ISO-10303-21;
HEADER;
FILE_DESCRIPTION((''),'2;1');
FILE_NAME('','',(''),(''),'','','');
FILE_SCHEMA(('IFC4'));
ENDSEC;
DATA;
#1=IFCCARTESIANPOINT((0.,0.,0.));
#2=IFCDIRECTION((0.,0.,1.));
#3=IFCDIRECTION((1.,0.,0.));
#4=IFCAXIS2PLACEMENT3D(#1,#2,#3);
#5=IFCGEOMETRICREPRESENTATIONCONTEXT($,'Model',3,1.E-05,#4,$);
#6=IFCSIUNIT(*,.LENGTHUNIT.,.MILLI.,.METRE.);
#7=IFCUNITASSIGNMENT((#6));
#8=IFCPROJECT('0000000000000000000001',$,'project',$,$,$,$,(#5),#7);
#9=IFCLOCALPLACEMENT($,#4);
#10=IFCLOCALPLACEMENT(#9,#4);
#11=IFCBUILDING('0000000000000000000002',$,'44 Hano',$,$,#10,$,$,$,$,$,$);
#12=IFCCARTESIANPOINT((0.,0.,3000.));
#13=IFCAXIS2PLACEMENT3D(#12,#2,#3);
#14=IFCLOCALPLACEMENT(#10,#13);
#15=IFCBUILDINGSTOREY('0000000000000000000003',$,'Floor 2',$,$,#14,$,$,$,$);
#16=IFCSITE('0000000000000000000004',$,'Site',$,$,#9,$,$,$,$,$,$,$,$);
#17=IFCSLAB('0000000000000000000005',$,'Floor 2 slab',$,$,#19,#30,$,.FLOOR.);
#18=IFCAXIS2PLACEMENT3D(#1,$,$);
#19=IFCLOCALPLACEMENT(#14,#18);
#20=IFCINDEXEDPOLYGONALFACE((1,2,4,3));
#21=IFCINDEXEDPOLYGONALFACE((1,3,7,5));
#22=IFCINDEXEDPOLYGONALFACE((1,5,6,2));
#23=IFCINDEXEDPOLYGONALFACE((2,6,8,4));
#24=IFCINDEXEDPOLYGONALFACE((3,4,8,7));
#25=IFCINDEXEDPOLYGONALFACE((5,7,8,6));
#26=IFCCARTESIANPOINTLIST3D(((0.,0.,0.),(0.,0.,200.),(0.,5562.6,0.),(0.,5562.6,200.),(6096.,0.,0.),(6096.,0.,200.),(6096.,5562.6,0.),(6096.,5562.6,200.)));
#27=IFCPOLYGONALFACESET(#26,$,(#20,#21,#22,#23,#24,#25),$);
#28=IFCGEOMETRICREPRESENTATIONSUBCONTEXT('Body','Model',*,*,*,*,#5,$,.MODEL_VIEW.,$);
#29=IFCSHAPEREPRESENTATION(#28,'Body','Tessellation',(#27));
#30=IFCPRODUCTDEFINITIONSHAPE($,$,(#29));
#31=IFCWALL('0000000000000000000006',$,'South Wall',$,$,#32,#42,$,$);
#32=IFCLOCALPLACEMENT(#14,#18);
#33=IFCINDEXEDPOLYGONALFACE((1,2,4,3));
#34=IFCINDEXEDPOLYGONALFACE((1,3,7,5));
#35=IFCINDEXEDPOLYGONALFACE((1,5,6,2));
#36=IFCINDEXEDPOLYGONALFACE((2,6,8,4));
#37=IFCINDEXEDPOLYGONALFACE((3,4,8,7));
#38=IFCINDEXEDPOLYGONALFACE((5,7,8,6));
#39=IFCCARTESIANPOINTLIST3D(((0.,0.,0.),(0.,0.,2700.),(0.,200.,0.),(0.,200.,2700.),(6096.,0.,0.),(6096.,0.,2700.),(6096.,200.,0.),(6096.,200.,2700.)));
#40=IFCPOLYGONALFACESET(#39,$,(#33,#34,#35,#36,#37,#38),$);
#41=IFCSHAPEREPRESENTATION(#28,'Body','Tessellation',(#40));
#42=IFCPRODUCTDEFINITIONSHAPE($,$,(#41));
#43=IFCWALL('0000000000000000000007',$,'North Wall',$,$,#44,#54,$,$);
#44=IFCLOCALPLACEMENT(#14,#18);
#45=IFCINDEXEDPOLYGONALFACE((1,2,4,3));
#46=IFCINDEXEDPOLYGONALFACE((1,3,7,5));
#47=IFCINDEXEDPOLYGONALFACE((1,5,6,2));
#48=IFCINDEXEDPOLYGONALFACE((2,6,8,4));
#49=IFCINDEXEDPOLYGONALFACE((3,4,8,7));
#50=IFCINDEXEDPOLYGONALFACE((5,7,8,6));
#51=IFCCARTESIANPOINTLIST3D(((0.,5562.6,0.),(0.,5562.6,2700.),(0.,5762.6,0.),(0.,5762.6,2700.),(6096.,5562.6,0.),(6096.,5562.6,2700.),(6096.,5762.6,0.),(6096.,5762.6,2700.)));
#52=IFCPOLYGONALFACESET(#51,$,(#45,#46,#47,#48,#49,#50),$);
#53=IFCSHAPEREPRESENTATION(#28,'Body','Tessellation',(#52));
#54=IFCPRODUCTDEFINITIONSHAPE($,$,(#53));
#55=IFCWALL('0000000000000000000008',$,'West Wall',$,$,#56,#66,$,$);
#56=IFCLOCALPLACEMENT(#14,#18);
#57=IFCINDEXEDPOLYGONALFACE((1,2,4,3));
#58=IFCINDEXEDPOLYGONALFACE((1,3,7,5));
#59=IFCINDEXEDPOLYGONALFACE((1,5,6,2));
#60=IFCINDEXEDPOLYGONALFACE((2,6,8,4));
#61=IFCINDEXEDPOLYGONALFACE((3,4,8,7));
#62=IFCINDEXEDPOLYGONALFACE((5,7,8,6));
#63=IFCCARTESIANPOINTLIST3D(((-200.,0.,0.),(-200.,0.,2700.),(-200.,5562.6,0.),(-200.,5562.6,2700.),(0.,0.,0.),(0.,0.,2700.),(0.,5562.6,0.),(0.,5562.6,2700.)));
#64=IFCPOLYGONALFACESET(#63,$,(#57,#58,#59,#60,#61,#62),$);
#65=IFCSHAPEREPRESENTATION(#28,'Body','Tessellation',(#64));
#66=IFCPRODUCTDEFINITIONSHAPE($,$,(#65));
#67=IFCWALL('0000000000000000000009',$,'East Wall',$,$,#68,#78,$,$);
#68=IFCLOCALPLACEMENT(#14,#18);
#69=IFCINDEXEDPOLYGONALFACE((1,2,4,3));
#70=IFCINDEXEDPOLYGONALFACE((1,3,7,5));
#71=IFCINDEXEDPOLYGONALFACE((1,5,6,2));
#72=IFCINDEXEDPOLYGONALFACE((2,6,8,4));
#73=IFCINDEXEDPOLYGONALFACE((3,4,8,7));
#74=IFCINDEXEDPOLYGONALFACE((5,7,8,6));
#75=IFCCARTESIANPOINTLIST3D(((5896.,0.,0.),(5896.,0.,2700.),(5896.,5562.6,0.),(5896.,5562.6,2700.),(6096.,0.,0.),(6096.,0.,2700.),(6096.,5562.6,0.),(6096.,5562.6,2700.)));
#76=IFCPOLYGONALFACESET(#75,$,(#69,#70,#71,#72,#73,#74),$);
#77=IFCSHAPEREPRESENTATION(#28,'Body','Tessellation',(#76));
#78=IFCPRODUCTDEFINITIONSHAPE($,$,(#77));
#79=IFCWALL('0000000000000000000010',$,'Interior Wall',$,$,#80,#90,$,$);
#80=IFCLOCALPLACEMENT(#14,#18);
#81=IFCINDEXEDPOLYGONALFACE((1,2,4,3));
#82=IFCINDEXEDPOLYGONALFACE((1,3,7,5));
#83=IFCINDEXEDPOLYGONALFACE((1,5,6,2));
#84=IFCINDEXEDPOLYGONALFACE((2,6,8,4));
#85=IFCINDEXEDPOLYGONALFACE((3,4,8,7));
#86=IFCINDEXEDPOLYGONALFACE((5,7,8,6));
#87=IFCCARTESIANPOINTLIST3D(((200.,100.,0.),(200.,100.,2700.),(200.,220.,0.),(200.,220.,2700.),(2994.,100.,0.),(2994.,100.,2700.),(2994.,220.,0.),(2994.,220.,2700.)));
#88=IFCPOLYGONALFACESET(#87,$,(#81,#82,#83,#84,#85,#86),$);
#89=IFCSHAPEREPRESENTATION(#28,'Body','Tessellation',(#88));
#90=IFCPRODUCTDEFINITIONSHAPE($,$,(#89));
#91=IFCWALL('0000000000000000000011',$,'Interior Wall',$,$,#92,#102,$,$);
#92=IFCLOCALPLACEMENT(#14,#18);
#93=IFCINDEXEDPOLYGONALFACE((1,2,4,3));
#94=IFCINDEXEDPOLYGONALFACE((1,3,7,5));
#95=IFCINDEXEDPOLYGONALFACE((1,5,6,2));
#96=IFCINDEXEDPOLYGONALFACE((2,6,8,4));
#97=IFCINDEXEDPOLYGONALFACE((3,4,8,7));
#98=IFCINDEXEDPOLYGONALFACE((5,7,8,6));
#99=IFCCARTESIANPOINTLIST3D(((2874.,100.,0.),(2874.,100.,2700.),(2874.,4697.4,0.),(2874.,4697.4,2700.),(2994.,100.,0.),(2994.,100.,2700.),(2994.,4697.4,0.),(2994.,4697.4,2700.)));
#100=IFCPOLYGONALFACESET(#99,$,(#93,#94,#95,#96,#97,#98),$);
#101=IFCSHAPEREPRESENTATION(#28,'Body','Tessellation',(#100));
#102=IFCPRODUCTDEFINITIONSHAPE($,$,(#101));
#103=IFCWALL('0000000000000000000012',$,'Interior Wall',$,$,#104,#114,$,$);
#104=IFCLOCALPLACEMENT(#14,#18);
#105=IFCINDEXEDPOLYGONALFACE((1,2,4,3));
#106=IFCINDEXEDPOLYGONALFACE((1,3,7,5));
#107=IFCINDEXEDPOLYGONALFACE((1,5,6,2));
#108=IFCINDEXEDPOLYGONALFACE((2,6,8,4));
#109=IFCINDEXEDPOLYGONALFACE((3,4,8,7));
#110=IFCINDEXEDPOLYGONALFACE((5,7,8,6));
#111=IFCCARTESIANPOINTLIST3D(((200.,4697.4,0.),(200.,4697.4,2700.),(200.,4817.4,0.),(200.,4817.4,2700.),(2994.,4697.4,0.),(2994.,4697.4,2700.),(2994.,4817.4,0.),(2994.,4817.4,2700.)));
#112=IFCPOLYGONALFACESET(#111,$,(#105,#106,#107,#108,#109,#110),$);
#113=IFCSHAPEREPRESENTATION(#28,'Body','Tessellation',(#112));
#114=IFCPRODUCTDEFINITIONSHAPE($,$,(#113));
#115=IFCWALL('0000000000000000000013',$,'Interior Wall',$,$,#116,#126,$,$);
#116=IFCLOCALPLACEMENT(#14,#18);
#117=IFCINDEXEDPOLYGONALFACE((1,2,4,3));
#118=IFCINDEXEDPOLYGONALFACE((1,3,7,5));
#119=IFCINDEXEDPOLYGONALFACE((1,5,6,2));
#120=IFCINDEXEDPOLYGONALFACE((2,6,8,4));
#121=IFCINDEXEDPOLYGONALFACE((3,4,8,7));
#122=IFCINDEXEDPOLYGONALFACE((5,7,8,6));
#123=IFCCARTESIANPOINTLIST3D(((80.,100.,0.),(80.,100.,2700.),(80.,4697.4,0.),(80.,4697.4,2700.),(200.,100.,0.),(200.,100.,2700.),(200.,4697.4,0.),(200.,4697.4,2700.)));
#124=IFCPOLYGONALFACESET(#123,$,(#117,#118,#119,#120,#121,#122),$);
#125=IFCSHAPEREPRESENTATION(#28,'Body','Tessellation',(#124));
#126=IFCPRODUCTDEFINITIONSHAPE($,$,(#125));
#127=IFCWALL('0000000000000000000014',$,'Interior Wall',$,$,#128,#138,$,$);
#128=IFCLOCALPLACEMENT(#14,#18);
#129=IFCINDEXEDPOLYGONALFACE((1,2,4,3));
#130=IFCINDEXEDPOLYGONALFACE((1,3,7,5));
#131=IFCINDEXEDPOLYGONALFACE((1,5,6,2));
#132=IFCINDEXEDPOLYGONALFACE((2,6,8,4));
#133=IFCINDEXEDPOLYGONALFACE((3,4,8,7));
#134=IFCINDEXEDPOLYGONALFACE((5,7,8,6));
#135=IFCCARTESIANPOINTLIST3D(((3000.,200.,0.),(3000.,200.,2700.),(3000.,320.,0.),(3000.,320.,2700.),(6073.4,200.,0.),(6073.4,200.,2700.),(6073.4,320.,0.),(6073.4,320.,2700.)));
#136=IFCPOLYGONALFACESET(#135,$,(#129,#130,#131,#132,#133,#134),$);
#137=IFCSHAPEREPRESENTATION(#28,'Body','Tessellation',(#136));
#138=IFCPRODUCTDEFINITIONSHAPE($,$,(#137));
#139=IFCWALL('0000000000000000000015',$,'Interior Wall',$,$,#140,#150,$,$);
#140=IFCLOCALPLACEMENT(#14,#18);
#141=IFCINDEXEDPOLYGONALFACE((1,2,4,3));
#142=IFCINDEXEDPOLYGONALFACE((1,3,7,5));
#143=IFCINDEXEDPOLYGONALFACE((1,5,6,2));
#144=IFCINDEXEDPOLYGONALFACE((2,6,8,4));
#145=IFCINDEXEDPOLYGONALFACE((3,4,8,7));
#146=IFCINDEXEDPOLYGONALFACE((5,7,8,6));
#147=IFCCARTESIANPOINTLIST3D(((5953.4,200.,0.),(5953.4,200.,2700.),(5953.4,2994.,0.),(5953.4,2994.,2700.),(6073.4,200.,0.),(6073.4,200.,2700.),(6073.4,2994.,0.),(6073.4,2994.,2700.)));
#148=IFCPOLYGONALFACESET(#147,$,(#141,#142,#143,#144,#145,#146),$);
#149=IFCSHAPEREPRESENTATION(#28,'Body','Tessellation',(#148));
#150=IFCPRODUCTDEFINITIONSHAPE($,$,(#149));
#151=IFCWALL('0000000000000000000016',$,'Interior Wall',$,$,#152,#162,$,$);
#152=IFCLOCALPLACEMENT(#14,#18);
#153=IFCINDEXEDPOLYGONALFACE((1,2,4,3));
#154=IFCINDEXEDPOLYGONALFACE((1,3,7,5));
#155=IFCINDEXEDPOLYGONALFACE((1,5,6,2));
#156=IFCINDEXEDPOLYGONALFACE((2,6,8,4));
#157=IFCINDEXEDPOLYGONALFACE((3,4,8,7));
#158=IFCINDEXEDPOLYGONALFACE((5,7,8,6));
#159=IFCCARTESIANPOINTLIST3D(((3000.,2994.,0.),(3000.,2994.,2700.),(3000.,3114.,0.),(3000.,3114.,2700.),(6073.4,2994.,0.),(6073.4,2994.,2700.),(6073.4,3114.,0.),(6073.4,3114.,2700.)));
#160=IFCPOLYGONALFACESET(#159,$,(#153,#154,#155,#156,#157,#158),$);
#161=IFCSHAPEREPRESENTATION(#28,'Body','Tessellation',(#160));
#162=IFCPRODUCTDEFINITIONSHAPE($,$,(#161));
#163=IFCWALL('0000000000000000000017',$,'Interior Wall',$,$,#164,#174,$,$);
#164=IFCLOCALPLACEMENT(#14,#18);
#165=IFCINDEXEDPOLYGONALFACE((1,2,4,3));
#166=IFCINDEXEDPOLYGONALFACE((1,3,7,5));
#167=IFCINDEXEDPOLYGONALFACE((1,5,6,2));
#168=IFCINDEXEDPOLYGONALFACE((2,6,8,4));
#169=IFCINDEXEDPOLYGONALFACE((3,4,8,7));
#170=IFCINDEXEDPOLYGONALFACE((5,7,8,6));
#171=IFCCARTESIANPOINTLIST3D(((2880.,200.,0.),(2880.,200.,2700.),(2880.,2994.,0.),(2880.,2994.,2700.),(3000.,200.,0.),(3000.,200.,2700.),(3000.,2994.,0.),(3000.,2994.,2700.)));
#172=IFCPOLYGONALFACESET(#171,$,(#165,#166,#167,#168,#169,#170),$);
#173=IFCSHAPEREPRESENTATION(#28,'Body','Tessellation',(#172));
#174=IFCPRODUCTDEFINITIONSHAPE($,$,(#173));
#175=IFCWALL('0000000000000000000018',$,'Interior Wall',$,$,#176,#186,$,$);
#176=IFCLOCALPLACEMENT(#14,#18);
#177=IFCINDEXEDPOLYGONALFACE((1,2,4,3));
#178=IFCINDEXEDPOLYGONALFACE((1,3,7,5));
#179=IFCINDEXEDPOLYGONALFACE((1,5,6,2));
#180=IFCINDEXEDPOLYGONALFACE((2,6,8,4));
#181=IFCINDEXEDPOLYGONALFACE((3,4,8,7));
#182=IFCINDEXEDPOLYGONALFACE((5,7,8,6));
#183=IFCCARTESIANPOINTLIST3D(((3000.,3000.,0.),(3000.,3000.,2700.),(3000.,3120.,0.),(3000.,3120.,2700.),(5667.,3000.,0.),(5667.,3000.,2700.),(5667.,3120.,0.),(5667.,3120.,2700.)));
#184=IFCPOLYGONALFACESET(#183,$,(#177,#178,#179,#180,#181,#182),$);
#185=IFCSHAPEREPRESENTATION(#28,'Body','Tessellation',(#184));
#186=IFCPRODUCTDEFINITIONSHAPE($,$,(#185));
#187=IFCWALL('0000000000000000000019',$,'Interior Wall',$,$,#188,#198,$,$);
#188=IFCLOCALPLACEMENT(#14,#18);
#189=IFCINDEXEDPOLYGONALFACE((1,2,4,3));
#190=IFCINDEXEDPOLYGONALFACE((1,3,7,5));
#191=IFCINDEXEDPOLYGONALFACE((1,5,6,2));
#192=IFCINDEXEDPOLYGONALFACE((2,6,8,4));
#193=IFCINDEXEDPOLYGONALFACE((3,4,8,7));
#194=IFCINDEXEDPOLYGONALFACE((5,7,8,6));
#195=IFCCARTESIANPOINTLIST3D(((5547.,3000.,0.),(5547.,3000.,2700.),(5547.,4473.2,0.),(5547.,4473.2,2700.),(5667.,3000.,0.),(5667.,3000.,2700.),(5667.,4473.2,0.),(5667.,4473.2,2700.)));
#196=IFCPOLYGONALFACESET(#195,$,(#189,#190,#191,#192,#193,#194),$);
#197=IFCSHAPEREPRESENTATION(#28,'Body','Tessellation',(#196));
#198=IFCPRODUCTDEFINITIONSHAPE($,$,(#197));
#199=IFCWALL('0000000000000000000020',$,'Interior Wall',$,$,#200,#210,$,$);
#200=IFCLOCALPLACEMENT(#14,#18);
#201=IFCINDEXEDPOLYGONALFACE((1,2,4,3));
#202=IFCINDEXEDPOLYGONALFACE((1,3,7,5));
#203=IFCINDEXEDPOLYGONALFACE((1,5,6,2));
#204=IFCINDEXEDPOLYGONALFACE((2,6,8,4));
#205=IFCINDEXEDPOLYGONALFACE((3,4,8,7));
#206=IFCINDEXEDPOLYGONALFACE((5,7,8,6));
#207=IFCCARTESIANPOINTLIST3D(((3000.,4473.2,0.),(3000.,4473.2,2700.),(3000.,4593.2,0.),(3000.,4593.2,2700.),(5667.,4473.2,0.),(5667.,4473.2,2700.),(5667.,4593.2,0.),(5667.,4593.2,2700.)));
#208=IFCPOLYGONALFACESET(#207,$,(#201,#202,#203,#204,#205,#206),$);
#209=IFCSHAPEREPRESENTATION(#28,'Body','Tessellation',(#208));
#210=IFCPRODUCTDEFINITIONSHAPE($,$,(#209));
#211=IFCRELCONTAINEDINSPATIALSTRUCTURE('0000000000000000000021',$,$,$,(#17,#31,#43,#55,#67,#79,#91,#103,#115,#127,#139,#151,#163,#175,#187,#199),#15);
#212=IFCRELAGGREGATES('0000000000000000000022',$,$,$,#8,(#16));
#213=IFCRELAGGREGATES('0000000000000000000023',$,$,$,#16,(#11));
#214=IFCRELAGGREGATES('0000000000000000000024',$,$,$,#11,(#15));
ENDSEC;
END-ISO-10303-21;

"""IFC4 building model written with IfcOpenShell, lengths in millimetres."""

from ifc_helpers import new_model, si_unit, frame, origin_with_axes, place, context, subcontext, project, spatial, indexed_curve, outline, extrude, element, save


model = new_model("IFC4")

# Units and contexts
model_context = context("Model", 3, precision=1e-05, world=origin_with_axes())
body_context = subcontext(model_context, "Body", "Model", "MODEL_VIEW")
ifc_project = project(units=[si_unit("LENGTHUNIT", "METRE", prefix="MILLI")], contexts=[model_context])

# Site, building, storey
site_placement = place(None, origin_with_axes())
site = spatial("IfcSite", under=ifc_project, at=site_placement, Name="Site")
building_placement = place(site_placement, origin_with_axes())
building = spatial("IfcBuilding", under=site, at=building_placement, Name="44 Hano")
storey_placement = place(building_placement, frame((0.0, 0.0, 3000.0), z_axis=(0.0, 0.0, 1.0), x_axis=(1.0, 0.0, 0.0)))
storey = spatial("IfcBuildingStorey", under=building, at=storey_placement, Name="Floor 2")

# Slab
slab_placement = place(storey_placement, origin_with_axes())
element("IfcSlab", 1, at=slab_placement, inside=storey, Name="Floor 2 slab", PredefinedType="FLOOR", context=body_context, shape_type="SweptSolid", body=[
    extrude(outline(indexed_curve([(0.0, 0.0), (6096.0, 0.0), (6096.0, 5562.6), (0.0, 5562.6), (0.0, 0.0)])), None, (0.0, 0.0, 1.0), 200.0),
])

# Walls
for number, where, z_axis, x_axis, name in (
    (2, (0.0, 0.0, 0.0), (0.0, 0.0, 1.0), (1.0, 0.0, 0.0), "South Wall"),
    (3, (0.0, 5562.6, 0.0), (0.0, 0.0, 1.0), (1.0, 0.0, 0.0), "North Wall"),
):
    element("IfcWall", number, at=place(storey_placement, frame(where, z_axis=z_axis, x_axis=x_axis)), inside=storey, Name=name, context=body_context, shape_type="SweptSolid", body=[
        extrude(outline(indexed_curve([(0.0, 0.0), (0.0, 200.0), (6096.0, 200.0), (6096.0, 0.0), (0.0, 0.0)], self_intersect=False)), origin_with_axes(), (0.0, 0.0, 1.0), 2700.0),
    ])
for number, where, z_axis, x_axis, name in (
    (4, (0.0, 0.0, 0.0), (0.0, 0.0, 1.0), (0.0, 1.0, 0.0), "West Wall"),
    (5, (6096.0, 0.0, 0.0), (0.0, 0.0, 1.0), (0.0, 1.0, 0.0), "East Wall"),
):
    element("IfcWall", number, at=place(storey_placement, frame(where, z_axis=z_axis, x_axis=x_axis)), inside=storey, Name=name, context=body_context, shape_type="SweptSolid", body=[
        extrude(outline(indexed_curve([(0.0, 0.0), (0.0, 200.0), (5562.6, 200.0), (5562.6, 0.0), (0.0, 0.0)], self_intersect=False)), origin_with_axes(), (0.0, 0.0, 1.0), 2700.0),
    ])
wall_1_placement = place(storey_placement, frame((200.0, 100.0, 0.0), z_axis=(0.0, 0.0, 1.0), x_axis=(1.0, 0.0, 0.0)))
element("IfcWall", 6, at=wall_1_placement, inside=storey, Name="Interior Wall", context=body_context, shape_type="SweptSolid", body=[
    extrude(outline(indexed_curve([(0.0, 0.0), (0.0, 120.0), (2794.0, 120.0), (2794.0, 0.0), (0.0, 0.0)], self_intersect=False)), origin_with_axes(), (0.0, 0.0, 1.0), 2700.0),
])
wall_2_placement = place(storey_placement, frame((2994.0, 100.0, 0.0), z_axis=(0.0, 0.0, 1.0), x_axis=(0.0, 1.0, 0.0)))
element("IfcWall", 7, at=wall_2_placement, inside=storey, Name="Interior Wall", context=body_context, shape_type="SweptSolid", body=[
    extrude(outline(indexed_curve([(0.0, 0.0), (0.0, 120.0), (4597.4, 120.0), (4597.4, 0.0), (0.0, 0.0)], self_intersect=False)), origin_with_axes(), (0.0, 0.0, 1.0), 2700.0),
])
wall_3_placement = place(storey_placement, frame((200.0, 4697.4, 0.0), z_axis=(0.0, 0.0, 1.0), x_axis=(1.0, 0.0, 0.0)))
element("IfcWall", 8, at=wall_3_placement, inside=storey, Name="Interior Wall", context=body_context, shape_type="SweptSolid", body=[
    extrude(outline(indexed_curve([(0.0, 0.0), (0.0, 120.0), (2794.0, 120.0), (2794.0, 0.0), (0.0, 0.0)], self_intersect=False)), origin_with_axes(), (0.0, 0.0, 1.0), 2700.0),
])
wall_4_placement = place(storey_placement, frame((200.0, 100.0, 0.0), z_axis=(0.0, 0.0, 1.0), x_axis=(0.0, 1.0, 0.0)))
element("IfcWall", 9, at=wall_4_placement, inside=storey, Name="Interior Wall", context=body_context, shape_type="SweptSolid", body=[
    extrude(outline(indexed_curve([(0.0, 0.0), (0.0, 120.0), (4597.4, 120.0), (4597.4, 0.0), (0.0, 0.0)], self_intersect=False)), origin_with_axes(), (0.0, 0.0, 1.0), 2700.0),
])
wall_5_placement = place(storey_placement, frame((3000.0, 200.0, 0.0), z_axis=(0.0, 0.0, 1.0), x_axis=(1.0, 0.0, 0.0)))
element("IfcWall", 10, at=wall_5_placement, inside=storey, Name="Interior Wall", context=body_context, shape_type="SweptSolid", body=[
    extrude(outline(indexed_curve([(0.0, 0.0), (0.0, 120.0), (3073.4, 120.0), (3073.4, 0.0), (0.0, 0.0)], self_intersect=False)), origin_with_axes(), (0.0, 0.0, 1.0), 2700.0),
])
wall_6_placement = place(storey_placement, frame((6073.4, 200.0, 0.0), z_axis=(0.0, 0.0, 1.0), x_axis=(0.0, 1.0, 0.0)))
element("IfcWall", 11, at=wall_6_placement, inside=storey, Name="Interior Wall", context=body_context, shape_type="SweptSolid", body=[
    extrude(outline(indexed_curve([(0.0, 0.0), (0.0, 120.0), (2794.0, 120.0), (2794.0, 0.0), (0.0, 0.0)], self_intersect=False)), origin_with_axes(), (0.0, 0.0, 1.0), 2700.0),
])
wall_7_placement = place(storey_placement, frame((3000.0, 2994.0, 0.0), z_axis=(0.0, 0.0, 1.0), x_axis=(1.0, 0.0, 0.0)))
element("IfcWall", 12, at=wall_7_placement, inside=storey, Name="Interior Wall", context=body_context, shape_type="SweptSolid", body=[
    extrude(outline(indexed_curve([(0.0, 0.0), (0.0, 120.0), (3073.4, 120.0), (3073.4, 0.0), (0.0, 0.0)], self_intersect=False)), origin_with_axes(), (0.0, 0.0, 1.0), 2700.0),
])
wall_8_placement = place(storey_placement, frame((3000.0, 200.0, 0.0), z_axis=(0.0, 0.0, 1.0), x_axis=(0.0, 1.0, 0.0)))
element("IfcWall", 13, at=wall_8_placement, inside=storey, Name="Interior Wall", context=body_context, shape_type="SweptSolid", body=[
    extrude(outline(indexed_curve([(0.0, 0.0), (0.0, 120.0), (2794.0, 120.0), (2794.0, 0.0), (0.0, 0.0)], self_intersect=False)), origin_with_axes(), (0.0, 0.0, 1.0), 2700.0),
])
wall_9_placement = place(storey_placement, frame((3000.0, 3000.0, 0.0), z_axis=(0.0, 0.0, 1.0), x_axis=(1.0, 0.0, 0.0)))
element("IfcWall", 14, at=wall_9_placement, inside=storey, Name="Interior Wall", context=body_context, shape_type="SweptSolid", body=[
    extrude(outline(indexed_curve([(0.0, 0.0), (0.0, 120.0), (2667.0, 120.0), (2667.0, 0.0), (0.0, 0.0)], self_intersect=False)), origin_with_axes(), (0.0, 0.0, 1.0), 2700.0),
])
wall_10_placement = place(storey_placement, frame((5667.0, 3000.0, 0.0), z_axis=(0.0, 0.0, 1.0), x_axis=(0.0, 1.0, 0.0)))
element("IfcWall", 15, at=wall_10_placement, inside=storey, Name="Interior Wall", context=body_context, shape_type="SweptSolid", body=[
    extrude(outline(indexed_curve([(0.0, 0.0), (0.0, 120.0), (1473.2, 120.0), (1473.2, 0.0), (0.0, 0.0)], self_intersect=False)), origin_with_axes(), (0.0, 0.0, 1.0), 2700.0),
])
wall_11_placement = place(storey_placement, frame((3000.0, 4473.2, 0.0), z_axis=(0.0, 0.0, 1.0), x_axis=(1.0, 0.0, 0.0)))
element("IfcWall", 16, at=wall_11_placement, inside=storey, Name="Interior Wall", context=body_context, shape_type="SweptSolid", body=[
    extrude(outline(indexed_curve([(0.0, 0.0), (0.0, 120.0), (2667.0, 120.0), (2667.0, 0.0), (0.0, 0.0)], self_intersect=False)), origin_with_axes(), (0.0, 0.0, 1.0), 2700.0),
])

save(model, "model.ifc")
